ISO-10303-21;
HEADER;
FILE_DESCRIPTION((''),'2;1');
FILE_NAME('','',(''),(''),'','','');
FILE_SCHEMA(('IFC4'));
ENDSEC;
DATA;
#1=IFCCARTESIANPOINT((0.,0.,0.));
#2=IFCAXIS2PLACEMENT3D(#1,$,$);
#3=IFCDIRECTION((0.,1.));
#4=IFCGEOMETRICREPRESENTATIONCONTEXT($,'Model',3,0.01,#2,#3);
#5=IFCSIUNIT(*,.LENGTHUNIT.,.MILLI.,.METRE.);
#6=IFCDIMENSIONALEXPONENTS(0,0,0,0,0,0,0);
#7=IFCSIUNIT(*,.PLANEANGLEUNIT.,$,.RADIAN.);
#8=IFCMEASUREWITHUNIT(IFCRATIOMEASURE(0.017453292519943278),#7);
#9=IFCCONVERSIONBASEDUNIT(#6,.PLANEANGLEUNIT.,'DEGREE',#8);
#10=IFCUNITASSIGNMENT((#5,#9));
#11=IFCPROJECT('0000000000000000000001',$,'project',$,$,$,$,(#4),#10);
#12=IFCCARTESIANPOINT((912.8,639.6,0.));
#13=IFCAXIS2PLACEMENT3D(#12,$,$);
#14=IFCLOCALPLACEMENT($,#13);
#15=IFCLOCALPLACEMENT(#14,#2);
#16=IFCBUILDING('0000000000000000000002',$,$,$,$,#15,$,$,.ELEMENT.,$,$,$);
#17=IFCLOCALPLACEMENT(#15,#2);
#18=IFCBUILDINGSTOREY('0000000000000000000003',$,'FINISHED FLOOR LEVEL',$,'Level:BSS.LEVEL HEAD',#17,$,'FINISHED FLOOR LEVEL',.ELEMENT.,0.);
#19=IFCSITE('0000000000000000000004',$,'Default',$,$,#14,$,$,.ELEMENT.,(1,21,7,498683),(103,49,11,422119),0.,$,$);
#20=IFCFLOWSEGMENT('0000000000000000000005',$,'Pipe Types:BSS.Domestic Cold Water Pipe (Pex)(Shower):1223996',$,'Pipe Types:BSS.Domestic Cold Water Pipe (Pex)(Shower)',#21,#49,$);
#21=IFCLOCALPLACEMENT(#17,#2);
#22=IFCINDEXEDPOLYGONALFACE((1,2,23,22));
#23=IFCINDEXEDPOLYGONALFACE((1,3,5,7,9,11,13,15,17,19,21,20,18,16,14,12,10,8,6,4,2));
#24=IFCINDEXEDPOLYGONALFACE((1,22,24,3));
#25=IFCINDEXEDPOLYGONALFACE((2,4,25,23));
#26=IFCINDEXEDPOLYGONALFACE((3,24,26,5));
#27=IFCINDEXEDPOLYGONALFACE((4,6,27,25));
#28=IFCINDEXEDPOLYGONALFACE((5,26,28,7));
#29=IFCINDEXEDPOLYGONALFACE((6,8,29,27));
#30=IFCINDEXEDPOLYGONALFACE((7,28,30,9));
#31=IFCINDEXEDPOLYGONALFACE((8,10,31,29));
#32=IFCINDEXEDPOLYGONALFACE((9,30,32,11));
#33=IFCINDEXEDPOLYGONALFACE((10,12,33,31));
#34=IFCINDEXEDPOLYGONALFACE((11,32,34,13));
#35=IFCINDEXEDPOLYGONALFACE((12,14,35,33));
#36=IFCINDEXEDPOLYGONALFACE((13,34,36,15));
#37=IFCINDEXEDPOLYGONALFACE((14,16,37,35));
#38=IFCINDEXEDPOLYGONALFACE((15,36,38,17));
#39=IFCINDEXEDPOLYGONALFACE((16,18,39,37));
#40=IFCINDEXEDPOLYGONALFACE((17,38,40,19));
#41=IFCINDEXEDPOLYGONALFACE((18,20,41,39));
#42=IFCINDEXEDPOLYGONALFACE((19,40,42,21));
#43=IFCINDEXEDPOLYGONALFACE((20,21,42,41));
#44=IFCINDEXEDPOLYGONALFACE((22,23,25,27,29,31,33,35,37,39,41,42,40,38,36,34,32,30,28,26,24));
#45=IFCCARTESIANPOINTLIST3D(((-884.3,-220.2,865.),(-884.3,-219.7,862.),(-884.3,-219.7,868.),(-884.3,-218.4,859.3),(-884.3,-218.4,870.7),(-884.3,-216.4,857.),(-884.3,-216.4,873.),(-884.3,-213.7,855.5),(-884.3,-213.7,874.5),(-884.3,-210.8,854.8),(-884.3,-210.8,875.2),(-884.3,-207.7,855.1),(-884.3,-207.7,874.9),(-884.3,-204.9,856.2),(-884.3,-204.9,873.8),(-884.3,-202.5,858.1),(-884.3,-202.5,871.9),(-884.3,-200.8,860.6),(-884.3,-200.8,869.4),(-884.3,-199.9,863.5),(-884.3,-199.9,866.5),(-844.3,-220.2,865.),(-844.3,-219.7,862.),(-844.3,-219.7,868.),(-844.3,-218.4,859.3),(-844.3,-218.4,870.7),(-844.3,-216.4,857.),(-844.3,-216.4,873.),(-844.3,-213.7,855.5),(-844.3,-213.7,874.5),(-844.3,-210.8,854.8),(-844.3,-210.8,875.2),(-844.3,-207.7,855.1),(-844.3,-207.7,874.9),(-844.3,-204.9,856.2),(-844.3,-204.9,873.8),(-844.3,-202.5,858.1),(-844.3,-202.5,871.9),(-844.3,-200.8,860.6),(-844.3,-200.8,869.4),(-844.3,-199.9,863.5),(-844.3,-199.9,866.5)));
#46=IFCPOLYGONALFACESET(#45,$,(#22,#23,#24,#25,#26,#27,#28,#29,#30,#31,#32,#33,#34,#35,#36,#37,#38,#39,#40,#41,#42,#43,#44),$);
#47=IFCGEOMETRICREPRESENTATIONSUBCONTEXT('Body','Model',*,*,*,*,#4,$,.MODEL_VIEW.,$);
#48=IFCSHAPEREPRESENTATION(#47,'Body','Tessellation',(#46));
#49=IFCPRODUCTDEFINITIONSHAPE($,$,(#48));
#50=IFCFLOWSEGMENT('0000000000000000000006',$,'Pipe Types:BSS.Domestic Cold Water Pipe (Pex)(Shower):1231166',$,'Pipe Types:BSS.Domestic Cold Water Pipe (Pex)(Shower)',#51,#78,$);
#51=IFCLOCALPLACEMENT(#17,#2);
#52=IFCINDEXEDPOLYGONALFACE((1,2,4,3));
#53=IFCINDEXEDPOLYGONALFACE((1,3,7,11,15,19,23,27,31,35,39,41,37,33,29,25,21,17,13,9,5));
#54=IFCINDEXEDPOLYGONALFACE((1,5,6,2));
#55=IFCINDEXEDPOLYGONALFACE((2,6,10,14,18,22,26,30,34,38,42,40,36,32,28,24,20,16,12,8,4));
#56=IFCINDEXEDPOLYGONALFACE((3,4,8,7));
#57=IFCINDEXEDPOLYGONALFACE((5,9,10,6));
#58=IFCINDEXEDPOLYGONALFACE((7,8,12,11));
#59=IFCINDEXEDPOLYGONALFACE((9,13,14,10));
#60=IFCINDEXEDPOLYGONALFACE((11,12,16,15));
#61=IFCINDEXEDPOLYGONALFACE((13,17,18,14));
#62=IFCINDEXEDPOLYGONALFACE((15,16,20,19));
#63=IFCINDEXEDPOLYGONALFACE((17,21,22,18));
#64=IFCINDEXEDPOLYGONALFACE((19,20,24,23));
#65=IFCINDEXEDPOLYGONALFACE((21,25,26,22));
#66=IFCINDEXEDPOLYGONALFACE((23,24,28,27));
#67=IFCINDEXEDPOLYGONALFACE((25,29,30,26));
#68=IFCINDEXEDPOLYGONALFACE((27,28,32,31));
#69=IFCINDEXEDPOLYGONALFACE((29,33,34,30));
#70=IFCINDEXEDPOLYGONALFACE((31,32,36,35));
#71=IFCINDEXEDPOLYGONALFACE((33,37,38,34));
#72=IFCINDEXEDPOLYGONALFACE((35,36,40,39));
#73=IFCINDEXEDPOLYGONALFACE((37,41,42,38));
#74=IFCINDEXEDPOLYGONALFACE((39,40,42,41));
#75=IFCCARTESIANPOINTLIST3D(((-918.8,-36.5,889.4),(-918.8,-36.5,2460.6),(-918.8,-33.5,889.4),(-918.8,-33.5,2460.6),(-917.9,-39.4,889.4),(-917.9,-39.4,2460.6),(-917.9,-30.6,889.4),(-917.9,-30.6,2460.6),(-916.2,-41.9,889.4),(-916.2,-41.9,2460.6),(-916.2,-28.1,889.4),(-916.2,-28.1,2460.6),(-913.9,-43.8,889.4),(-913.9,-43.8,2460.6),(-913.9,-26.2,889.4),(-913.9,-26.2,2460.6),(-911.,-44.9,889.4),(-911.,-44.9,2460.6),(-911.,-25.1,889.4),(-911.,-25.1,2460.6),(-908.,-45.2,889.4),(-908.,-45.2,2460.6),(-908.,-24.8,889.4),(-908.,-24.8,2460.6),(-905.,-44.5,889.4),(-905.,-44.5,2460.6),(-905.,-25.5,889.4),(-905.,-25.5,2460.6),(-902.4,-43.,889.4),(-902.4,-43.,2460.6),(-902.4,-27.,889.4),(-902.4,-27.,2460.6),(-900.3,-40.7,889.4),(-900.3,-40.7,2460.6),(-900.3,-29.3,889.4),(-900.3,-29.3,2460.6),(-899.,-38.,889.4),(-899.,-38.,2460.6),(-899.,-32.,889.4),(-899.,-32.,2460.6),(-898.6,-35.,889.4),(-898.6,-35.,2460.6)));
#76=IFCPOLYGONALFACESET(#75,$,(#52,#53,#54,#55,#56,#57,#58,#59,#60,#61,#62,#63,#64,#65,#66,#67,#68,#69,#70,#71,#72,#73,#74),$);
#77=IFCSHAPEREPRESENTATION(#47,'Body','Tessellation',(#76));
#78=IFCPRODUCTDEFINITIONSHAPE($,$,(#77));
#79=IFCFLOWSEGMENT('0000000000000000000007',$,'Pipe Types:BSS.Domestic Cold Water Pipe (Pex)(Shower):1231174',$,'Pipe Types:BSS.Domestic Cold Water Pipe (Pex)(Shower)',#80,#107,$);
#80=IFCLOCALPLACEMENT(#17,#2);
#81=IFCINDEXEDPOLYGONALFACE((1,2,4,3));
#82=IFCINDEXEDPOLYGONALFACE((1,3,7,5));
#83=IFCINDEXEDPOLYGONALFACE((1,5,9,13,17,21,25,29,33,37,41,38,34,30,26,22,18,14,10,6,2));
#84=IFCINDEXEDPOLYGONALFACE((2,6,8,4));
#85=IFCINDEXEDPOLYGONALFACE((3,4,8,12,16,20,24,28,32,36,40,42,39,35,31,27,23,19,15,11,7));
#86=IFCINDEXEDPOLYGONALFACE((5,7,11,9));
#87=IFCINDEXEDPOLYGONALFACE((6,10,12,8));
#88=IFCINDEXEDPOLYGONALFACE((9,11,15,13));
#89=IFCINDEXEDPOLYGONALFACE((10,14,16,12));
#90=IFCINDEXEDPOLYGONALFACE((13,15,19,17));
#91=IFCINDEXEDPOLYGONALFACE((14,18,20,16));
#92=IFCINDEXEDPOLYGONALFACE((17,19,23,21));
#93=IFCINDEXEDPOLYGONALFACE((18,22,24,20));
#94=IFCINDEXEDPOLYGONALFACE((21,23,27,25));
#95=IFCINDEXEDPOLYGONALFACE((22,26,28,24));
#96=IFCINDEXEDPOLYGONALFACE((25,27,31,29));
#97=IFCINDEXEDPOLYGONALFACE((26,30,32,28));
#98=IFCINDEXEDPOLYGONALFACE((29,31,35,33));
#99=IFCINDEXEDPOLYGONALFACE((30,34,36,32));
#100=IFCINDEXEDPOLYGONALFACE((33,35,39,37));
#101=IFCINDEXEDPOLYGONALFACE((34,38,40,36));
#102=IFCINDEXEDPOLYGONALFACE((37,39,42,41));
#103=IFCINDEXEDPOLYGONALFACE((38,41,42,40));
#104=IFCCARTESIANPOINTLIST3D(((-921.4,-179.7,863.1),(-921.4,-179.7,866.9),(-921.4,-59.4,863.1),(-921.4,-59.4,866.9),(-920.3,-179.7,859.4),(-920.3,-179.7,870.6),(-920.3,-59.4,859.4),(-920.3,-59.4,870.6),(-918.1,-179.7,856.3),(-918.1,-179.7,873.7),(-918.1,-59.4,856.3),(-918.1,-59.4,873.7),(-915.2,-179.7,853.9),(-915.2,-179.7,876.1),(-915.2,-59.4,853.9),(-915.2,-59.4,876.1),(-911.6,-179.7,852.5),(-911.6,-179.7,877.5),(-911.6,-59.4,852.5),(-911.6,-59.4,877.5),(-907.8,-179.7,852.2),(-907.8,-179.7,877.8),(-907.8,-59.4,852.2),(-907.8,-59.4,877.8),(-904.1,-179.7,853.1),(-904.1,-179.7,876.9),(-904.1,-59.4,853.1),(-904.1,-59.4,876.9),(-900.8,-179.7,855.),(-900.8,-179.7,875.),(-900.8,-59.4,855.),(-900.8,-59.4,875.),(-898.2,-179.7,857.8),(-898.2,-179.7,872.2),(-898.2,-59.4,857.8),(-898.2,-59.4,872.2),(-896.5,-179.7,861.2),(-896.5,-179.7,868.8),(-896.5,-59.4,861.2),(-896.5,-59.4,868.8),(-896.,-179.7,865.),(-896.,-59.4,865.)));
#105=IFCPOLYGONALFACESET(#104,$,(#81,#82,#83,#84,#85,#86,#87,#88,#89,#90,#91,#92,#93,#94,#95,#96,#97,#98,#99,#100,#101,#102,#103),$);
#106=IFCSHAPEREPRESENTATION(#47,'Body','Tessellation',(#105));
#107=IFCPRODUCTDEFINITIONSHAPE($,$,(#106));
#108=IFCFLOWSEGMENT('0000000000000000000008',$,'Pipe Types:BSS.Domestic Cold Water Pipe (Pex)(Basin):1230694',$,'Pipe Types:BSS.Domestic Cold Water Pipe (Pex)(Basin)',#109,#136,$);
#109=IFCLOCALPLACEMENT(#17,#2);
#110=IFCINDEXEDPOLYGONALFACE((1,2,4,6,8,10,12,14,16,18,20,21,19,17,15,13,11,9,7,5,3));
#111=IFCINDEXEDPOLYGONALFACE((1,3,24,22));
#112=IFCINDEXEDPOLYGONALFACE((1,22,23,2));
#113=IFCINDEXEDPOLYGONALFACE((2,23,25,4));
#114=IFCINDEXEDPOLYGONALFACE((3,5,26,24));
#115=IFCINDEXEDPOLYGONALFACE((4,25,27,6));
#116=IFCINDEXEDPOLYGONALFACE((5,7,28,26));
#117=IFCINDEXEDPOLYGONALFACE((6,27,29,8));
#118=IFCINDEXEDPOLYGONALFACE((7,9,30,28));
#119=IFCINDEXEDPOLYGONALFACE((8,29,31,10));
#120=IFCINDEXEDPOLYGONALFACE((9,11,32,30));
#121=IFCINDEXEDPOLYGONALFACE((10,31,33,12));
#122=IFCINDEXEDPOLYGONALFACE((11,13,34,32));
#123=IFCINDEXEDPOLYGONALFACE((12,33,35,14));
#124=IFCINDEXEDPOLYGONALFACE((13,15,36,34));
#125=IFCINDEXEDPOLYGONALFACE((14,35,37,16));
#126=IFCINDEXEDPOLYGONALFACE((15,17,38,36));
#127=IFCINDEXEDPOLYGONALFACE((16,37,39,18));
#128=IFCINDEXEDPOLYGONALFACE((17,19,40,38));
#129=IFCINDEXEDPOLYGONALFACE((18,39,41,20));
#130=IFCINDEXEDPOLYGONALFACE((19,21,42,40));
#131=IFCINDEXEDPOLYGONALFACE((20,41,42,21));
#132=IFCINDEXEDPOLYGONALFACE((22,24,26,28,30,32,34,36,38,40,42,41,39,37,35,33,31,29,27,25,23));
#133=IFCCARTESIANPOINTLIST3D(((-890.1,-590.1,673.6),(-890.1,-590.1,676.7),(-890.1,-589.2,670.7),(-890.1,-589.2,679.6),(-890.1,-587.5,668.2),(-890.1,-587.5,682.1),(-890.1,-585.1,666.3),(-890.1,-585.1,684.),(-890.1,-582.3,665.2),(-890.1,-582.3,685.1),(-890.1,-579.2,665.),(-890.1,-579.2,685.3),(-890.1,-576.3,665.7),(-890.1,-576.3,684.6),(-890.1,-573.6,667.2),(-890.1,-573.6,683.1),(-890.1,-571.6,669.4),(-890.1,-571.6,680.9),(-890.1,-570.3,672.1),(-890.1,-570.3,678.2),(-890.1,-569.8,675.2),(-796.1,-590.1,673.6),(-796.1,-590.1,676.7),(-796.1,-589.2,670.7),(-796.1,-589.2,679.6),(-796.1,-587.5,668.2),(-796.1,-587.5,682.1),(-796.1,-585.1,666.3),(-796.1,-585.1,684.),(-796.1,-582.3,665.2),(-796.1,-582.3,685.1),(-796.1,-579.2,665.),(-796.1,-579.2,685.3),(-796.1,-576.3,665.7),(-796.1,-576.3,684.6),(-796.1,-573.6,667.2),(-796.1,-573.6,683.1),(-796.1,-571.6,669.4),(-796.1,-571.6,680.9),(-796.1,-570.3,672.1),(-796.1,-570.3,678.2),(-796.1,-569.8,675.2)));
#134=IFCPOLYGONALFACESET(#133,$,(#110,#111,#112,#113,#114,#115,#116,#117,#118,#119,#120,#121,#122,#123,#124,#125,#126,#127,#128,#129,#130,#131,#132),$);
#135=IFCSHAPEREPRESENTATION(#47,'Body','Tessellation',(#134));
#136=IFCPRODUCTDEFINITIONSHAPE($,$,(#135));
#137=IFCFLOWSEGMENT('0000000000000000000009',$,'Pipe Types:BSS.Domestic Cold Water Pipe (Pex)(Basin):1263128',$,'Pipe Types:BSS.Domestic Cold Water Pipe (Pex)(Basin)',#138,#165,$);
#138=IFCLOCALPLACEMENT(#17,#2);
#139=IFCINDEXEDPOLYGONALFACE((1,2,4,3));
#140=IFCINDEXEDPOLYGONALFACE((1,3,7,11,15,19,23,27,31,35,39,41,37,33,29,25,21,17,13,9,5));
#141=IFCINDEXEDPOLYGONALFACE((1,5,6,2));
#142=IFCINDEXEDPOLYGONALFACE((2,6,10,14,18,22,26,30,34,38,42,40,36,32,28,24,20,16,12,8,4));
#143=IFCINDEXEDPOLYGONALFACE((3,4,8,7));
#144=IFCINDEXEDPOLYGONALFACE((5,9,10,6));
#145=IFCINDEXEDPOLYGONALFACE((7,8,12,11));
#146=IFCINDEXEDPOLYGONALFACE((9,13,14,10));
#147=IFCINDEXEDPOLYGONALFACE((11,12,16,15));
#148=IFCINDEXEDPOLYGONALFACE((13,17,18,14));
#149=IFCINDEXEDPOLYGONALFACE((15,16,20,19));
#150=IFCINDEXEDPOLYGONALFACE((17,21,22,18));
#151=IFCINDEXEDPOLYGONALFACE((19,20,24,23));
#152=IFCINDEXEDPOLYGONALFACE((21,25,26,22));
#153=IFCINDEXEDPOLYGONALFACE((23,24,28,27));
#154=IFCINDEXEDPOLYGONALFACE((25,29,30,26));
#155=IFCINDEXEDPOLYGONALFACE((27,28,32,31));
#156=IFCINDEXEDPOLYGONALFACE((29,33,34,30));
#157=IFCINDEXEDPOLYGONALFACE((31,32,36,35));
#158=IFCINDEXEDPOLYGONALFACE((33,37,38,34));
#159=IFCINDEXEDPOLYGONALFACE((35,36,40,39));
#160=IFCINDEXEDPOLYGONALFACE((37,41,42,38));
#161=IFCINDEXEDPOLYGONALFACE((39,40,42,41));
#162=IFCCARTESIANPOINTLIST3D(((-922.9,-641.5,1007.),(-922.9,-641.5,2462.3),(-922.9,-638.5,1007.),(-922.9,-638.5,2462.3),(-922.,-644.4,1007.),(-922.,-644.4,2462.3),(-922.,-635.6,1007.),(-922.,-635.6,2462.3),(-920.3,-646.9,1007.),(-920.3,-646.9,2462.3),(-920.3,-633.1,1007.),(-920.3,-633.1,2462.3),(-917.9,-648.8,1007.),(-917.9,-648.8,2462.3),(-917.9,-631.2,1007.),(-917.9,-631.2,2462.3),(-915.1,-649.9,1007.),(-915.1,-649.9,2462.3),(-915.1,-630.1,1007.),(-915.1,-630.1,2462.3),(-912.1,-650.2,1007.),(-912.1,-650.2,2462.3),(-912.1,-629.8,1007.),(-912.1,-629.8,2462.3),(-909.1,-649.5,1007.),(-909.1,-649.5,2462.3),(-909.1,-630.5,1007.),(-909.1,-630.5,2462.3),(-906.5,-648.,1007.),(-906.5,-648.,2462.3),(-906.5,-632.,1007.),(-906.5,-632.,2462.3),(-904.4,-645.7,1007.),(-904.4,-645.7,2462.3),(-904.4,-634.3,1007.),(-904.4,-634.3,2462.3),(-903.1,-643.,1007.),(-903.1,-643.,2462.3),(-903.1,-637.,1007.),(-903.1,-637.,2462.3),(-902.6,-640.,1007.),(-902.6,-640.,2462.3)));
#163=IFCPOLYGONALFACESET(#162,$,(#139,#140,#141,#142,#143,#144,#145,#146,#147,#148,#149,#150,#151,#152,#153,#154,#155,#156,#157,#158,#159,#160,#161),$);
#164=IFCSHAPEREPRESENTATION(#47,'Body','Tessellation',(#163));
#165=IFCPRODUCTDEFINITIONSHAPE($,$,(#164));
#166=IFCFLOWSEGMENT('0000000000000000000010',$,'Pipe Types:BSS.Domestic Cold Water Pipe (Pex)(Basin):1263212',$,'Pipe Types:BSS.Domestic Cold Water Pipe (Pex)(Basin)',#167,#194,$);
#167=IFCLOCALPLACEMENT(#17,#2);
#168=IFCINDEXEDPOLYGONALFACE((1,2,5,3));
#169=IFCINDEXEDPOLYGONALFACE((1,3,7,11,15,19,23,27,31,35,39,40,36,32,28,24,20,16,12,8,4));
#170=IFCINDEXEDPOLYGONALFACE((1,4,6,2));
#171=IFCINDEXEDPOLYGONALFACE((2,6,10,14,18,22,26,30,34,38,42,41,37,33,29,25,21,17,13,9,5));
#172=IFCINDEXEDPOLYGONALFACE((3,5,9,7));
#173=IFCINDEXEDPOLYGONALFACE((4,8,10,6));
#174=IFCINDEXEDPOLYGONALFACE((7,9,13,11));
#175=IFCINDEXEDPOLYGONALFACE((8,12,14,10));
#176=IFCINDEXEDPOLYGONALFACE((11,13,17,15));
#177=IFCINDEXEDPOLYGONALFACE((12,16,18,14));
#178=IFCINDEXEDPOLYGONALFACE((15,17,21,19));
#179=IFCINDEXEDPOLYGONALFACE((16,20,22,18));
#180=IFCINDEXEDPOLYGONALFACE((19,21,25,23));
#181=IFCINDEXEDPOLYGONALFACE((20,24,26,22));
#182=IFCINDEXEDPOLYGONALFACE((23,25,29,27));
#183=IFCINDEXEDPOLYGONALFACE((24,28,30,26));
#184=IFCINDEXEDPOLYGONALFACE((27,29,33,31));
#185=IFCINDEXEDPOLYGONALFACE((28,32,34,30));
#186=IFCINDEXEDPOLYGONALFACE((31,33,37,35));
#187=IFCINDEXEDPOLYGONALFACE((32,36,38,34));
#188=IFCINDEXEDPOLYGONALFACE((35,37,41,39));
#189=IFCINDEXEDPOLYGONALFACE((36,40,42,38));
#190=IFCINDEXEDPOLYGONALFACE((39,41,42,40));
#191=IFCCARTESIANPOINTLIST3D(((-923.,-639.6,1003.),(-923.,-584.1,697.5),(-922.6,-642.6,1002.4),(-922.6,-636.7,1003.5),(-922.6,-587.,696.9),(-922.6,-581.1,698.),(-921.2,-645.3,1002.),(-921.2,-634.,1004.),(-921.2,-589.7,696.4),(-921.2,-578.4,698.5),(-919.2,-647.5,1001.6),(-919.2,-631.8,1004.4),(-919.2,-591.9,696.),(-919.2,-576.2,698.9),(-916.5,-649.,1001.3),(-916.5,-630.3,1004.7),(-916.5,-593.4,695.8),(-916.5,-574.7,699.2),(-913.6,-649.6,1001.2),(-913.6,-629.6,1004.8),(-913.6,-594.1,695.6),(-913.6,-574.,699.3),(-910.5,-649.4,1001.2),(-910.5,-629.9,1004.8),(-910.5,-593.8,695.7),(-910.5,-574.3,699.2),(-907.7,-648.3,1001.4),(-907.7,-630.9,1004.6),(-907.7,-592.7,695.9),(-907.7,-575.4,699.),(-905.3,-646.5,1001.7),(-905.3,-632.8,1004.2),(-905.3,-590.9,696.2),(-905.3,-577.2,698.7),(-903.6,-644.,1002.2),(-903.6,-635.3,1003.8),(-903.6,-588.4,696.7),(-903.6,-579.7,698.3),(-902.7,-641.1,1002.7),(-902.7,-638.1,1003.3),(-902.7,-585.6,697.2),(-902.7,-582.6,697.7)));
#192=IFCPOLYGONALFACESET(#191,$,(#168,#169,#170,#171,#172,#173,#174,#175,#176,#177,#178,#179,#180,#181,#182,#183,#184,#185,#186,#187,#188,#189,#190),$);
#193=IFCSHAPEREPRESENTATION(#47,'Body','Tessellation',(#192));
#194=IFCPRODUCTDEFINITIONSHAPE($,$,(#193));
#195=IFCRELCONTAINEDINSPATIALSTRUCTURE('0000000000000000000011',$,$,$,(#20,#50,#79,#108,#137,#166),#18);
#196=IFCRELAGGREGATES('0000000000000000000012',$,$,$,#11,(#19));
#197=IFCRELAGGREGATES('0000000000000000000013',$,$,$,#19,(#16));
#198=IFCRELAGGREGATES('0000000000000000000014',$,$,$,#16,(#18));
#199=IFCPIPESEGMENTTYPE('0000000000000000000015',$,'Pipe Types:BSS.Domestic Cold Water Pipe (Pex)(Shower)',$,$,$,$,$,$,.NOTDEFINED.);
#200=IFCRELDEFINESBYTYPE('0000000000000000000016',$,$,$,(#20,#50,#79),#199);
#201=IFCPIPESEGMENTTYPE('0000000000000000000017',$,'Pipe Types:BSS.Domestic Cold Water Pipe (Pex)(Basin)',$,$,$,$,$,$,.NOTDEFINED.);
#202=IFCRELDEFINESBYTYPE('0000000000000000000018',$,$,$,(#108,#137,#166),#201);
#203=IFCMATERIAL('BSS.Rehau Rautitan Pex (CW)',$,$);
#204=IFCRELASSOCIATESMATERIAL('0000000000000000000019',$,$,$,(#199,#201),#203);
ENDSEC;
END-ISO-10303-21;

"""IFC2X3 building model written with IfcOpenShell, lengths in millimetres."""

from ifc_helpers import new_model, entity, si_unit, converted_unit, direction, frame, frame_2d, origin, origin_2d_with_axis, place, context, subcontext, project, spatial, circle, extrude, material, type_object, element, save


model = new_model("IFC2X3")

# Units and contexts
model_context = context("Model", 3, precision=0.01, world=origin(), true_north=direction((0.0, 1.0)))
body_context = subcontext(model_context, "Body", "Model", "MODEL_VIEW")
ifc_project = project(units=[si_unit("LENGTHUNIT", "METRE", prefix="MILLI"), converted_unit("PLANEANGLEUNIT", "DEGREE", entity("IfcRatioMeasure", 0.017453292519943278), si_unit("PLANEANGLEUNIT", "RADIAN"), dimensions=[0, 0, 0, 0, 0, 0, 0])], contexts=[model_context])

# Site, building, storey
site_placement = place(None, frame((912.8, 639.6, 0.0)))
site = spatial("IfcSite", under=ifc_project, at=site_placement, Name="Default", CompositionType="ELEMENT", RefLatitude=(1, 21, 7, 498683), RefLongitude=(103, 49, 11, 422119), RefElevation=0.0)
building_placement = place(site_placement, origin())
building = spatial("IfcBuilding", under=site, at=building_placement, CompositionType="ELEMENT")
storey_placement = place(building_placement, origin())
storey = spatial("IfcBuildingStorey", under=building, at=storey_placement, Name="FINISHED FLOOR LEVEL", ObjectType="Level:BSS.LEVEL HEAD", LongName="FINISHED FLOOR LEVEL", CompositionType="ELEMENT", Elevation=0.0)

# Flow segments
ifc_material_1 = material(Name="BSS.Rehau Rautitan Pex (CW)")
pipe_segment_type_1 = type_object("IfcPipeSegmentType", Name="Pipe Types:BSS.Domestic Cold Water Pipe (Pex)(Shower)", PredefinedType="NOTDEFINED", material=ifc_material_1)
flow_segment_1_placement = place(storey_placement, origin())
element("IfcFlowSegment", 1, at=flow_segment_1_placement, inside=storey, type_object=pipe_segment_type_1, Name="Pipe Types:BSS.Domestic Cold Water Pipe (Pex)(Shower):1223996", ObjectType="Pipe Types:BSS.Domestic Cold Water Pipe (Pex)(Shower)", context=body_context, shape_type="SweptSolid", body=[
    extrude(circle(Radius=10.2, at=frame_2d((0.0, 0.0), x_axis=(1.0, 0.0))), frame((-884.3, -210.0, 865.0), z_axis=(1.0, 0.0, 0.0), x_axis=(0.0, -1.0, 0.0)), (0.0, 0.0, 1.0), 40.0),
])
flow_segment_2_placement = place(storey_placement, origin())
element("IfcFlowSegment", 2, at=flow_segment_2_placement, inside=storey, type_object=pipe_segment_type_1, Name="Pipe Types:BSS.Domestic Cold Water Pipe (Pex)(Shower):1231166", ObjectType="Pipe Types:BSS.Domestic Cold Water Pipe (Pex)(Shower)", context=body_context, shape_type="SweptSolid", body=[
    extrude(circle(Radius=10.2, at=frame_2d((0.0, 0.0), x_axis=(1.0, 0.0))), frame((-908.8, -35.0, 889.4)), (0.0, 0.0, 1.0), 1571.1),
])
flow_segment_3_placement = place(storey_placement, origin())
element("IfcFlowSegment", 3, at=flow_segment_3_placement, inside=storey, type_object=pipe_segment_type_1, Name="Pipe Types:BSS.Domestic Cold Water Pipe (Pex)(Shower):1231174", ObjectType="Pipe Types:BSS.Domestic Cold Water Pipe (Pex)(Shower)", context=body_context, shape_type="SweptSolid", body=[
    extrude(circle(Radius=12.8, at=frame_2d((0.0, 0.0), x_axis=(1.0, 0.0))), frame((-908.8, -179.7, 865.0), z_axis=(0.0, 1.0, 0.0), x_axis=(1.0, 0.0, 0.0)), (0.0, 0.0, 1.0), 120.2),
])
pipe_segment_type_2 = type_object("IfcPipeSegmentType", Name="Pipe Types:BSS.Domestic Cold Water Pipe (Pex)(Basin)", PredefinedType="NOTDEFINED", material=ifc_material_1)
flow_segment_4_placement = place(storey_placement, origin())
element("IfcFlowSegment", 4, at=flow_segment_4_placement, inside=storey, type_object=pipe_segment_type_2, Name="Pipe Types:BSS.Domestic Cold Water Pipe (Pex)(Basin):1230694", ObjectType="Pipe Types:BSS.Domestic Cold Water Pipe (Pex)(Basin)", context=body_context, shape_type="SweptSolid", body=[
    extrude(circle(Radius=10.2, at=origin_2d_with_axis()), frame((-890.1, -580.0, 675.2), z_axis=(1.0, 0.0, 0.0), x_axis=(0.0, 1.0, 0.0)), (0.0, 0.0, 1.0), 94.0),
])
flow_segment_5_placement = place(storey_placement, origin())
element("IfcFlowSegment", 5, at=flow_segment_5_placement, inside=storey, type_object=pipe_segment_type_2, Name="Pipe Types:BSS.Domestic Cold Water Pipe (Pex)(Basin):1263128", ObjectType="Pipe Types:BSS.Domestic Cold Water Pipe (Pex)(Basin)", context=body_context, shape_type="SweptSolid", body=[
    extrude(circle(Radius=10.2, at=origin_2d_with_axis()), frame((-912.8, -640.0, 1007.0)), (0.0, 0.0, 1.0), 1455.3),
])
flow_segment_6_placement = place(storey_placement, origin())
element("IfcFlowSegment", 6, at=flow_segment_6_placement, inside=storey, type_object=pipe_segment_type_2, Name="Pipe Types:BSS.Domestic Cold Water Pipe (Pex)(Basin):1263212", ObjectType="Pipe Types:BSS.Domestic Cold Water Pipe (Pex)(Basin)", context=body_context, shape_type="SweptSolid", body=[
    extrude(circle(Radius=10.2, at=frame_2d((0.0, 0.0), x_axis=(1.0, 0.0))), frame((-912.8, -584.1, 697.5), z_axis=(0.0, -0.178966, 0.983855), x_axis=(-1.0, 0.0, 0.0)), (0.0, 0.0, 1.0), 310.5),
])

save(model, "model.ifc")
